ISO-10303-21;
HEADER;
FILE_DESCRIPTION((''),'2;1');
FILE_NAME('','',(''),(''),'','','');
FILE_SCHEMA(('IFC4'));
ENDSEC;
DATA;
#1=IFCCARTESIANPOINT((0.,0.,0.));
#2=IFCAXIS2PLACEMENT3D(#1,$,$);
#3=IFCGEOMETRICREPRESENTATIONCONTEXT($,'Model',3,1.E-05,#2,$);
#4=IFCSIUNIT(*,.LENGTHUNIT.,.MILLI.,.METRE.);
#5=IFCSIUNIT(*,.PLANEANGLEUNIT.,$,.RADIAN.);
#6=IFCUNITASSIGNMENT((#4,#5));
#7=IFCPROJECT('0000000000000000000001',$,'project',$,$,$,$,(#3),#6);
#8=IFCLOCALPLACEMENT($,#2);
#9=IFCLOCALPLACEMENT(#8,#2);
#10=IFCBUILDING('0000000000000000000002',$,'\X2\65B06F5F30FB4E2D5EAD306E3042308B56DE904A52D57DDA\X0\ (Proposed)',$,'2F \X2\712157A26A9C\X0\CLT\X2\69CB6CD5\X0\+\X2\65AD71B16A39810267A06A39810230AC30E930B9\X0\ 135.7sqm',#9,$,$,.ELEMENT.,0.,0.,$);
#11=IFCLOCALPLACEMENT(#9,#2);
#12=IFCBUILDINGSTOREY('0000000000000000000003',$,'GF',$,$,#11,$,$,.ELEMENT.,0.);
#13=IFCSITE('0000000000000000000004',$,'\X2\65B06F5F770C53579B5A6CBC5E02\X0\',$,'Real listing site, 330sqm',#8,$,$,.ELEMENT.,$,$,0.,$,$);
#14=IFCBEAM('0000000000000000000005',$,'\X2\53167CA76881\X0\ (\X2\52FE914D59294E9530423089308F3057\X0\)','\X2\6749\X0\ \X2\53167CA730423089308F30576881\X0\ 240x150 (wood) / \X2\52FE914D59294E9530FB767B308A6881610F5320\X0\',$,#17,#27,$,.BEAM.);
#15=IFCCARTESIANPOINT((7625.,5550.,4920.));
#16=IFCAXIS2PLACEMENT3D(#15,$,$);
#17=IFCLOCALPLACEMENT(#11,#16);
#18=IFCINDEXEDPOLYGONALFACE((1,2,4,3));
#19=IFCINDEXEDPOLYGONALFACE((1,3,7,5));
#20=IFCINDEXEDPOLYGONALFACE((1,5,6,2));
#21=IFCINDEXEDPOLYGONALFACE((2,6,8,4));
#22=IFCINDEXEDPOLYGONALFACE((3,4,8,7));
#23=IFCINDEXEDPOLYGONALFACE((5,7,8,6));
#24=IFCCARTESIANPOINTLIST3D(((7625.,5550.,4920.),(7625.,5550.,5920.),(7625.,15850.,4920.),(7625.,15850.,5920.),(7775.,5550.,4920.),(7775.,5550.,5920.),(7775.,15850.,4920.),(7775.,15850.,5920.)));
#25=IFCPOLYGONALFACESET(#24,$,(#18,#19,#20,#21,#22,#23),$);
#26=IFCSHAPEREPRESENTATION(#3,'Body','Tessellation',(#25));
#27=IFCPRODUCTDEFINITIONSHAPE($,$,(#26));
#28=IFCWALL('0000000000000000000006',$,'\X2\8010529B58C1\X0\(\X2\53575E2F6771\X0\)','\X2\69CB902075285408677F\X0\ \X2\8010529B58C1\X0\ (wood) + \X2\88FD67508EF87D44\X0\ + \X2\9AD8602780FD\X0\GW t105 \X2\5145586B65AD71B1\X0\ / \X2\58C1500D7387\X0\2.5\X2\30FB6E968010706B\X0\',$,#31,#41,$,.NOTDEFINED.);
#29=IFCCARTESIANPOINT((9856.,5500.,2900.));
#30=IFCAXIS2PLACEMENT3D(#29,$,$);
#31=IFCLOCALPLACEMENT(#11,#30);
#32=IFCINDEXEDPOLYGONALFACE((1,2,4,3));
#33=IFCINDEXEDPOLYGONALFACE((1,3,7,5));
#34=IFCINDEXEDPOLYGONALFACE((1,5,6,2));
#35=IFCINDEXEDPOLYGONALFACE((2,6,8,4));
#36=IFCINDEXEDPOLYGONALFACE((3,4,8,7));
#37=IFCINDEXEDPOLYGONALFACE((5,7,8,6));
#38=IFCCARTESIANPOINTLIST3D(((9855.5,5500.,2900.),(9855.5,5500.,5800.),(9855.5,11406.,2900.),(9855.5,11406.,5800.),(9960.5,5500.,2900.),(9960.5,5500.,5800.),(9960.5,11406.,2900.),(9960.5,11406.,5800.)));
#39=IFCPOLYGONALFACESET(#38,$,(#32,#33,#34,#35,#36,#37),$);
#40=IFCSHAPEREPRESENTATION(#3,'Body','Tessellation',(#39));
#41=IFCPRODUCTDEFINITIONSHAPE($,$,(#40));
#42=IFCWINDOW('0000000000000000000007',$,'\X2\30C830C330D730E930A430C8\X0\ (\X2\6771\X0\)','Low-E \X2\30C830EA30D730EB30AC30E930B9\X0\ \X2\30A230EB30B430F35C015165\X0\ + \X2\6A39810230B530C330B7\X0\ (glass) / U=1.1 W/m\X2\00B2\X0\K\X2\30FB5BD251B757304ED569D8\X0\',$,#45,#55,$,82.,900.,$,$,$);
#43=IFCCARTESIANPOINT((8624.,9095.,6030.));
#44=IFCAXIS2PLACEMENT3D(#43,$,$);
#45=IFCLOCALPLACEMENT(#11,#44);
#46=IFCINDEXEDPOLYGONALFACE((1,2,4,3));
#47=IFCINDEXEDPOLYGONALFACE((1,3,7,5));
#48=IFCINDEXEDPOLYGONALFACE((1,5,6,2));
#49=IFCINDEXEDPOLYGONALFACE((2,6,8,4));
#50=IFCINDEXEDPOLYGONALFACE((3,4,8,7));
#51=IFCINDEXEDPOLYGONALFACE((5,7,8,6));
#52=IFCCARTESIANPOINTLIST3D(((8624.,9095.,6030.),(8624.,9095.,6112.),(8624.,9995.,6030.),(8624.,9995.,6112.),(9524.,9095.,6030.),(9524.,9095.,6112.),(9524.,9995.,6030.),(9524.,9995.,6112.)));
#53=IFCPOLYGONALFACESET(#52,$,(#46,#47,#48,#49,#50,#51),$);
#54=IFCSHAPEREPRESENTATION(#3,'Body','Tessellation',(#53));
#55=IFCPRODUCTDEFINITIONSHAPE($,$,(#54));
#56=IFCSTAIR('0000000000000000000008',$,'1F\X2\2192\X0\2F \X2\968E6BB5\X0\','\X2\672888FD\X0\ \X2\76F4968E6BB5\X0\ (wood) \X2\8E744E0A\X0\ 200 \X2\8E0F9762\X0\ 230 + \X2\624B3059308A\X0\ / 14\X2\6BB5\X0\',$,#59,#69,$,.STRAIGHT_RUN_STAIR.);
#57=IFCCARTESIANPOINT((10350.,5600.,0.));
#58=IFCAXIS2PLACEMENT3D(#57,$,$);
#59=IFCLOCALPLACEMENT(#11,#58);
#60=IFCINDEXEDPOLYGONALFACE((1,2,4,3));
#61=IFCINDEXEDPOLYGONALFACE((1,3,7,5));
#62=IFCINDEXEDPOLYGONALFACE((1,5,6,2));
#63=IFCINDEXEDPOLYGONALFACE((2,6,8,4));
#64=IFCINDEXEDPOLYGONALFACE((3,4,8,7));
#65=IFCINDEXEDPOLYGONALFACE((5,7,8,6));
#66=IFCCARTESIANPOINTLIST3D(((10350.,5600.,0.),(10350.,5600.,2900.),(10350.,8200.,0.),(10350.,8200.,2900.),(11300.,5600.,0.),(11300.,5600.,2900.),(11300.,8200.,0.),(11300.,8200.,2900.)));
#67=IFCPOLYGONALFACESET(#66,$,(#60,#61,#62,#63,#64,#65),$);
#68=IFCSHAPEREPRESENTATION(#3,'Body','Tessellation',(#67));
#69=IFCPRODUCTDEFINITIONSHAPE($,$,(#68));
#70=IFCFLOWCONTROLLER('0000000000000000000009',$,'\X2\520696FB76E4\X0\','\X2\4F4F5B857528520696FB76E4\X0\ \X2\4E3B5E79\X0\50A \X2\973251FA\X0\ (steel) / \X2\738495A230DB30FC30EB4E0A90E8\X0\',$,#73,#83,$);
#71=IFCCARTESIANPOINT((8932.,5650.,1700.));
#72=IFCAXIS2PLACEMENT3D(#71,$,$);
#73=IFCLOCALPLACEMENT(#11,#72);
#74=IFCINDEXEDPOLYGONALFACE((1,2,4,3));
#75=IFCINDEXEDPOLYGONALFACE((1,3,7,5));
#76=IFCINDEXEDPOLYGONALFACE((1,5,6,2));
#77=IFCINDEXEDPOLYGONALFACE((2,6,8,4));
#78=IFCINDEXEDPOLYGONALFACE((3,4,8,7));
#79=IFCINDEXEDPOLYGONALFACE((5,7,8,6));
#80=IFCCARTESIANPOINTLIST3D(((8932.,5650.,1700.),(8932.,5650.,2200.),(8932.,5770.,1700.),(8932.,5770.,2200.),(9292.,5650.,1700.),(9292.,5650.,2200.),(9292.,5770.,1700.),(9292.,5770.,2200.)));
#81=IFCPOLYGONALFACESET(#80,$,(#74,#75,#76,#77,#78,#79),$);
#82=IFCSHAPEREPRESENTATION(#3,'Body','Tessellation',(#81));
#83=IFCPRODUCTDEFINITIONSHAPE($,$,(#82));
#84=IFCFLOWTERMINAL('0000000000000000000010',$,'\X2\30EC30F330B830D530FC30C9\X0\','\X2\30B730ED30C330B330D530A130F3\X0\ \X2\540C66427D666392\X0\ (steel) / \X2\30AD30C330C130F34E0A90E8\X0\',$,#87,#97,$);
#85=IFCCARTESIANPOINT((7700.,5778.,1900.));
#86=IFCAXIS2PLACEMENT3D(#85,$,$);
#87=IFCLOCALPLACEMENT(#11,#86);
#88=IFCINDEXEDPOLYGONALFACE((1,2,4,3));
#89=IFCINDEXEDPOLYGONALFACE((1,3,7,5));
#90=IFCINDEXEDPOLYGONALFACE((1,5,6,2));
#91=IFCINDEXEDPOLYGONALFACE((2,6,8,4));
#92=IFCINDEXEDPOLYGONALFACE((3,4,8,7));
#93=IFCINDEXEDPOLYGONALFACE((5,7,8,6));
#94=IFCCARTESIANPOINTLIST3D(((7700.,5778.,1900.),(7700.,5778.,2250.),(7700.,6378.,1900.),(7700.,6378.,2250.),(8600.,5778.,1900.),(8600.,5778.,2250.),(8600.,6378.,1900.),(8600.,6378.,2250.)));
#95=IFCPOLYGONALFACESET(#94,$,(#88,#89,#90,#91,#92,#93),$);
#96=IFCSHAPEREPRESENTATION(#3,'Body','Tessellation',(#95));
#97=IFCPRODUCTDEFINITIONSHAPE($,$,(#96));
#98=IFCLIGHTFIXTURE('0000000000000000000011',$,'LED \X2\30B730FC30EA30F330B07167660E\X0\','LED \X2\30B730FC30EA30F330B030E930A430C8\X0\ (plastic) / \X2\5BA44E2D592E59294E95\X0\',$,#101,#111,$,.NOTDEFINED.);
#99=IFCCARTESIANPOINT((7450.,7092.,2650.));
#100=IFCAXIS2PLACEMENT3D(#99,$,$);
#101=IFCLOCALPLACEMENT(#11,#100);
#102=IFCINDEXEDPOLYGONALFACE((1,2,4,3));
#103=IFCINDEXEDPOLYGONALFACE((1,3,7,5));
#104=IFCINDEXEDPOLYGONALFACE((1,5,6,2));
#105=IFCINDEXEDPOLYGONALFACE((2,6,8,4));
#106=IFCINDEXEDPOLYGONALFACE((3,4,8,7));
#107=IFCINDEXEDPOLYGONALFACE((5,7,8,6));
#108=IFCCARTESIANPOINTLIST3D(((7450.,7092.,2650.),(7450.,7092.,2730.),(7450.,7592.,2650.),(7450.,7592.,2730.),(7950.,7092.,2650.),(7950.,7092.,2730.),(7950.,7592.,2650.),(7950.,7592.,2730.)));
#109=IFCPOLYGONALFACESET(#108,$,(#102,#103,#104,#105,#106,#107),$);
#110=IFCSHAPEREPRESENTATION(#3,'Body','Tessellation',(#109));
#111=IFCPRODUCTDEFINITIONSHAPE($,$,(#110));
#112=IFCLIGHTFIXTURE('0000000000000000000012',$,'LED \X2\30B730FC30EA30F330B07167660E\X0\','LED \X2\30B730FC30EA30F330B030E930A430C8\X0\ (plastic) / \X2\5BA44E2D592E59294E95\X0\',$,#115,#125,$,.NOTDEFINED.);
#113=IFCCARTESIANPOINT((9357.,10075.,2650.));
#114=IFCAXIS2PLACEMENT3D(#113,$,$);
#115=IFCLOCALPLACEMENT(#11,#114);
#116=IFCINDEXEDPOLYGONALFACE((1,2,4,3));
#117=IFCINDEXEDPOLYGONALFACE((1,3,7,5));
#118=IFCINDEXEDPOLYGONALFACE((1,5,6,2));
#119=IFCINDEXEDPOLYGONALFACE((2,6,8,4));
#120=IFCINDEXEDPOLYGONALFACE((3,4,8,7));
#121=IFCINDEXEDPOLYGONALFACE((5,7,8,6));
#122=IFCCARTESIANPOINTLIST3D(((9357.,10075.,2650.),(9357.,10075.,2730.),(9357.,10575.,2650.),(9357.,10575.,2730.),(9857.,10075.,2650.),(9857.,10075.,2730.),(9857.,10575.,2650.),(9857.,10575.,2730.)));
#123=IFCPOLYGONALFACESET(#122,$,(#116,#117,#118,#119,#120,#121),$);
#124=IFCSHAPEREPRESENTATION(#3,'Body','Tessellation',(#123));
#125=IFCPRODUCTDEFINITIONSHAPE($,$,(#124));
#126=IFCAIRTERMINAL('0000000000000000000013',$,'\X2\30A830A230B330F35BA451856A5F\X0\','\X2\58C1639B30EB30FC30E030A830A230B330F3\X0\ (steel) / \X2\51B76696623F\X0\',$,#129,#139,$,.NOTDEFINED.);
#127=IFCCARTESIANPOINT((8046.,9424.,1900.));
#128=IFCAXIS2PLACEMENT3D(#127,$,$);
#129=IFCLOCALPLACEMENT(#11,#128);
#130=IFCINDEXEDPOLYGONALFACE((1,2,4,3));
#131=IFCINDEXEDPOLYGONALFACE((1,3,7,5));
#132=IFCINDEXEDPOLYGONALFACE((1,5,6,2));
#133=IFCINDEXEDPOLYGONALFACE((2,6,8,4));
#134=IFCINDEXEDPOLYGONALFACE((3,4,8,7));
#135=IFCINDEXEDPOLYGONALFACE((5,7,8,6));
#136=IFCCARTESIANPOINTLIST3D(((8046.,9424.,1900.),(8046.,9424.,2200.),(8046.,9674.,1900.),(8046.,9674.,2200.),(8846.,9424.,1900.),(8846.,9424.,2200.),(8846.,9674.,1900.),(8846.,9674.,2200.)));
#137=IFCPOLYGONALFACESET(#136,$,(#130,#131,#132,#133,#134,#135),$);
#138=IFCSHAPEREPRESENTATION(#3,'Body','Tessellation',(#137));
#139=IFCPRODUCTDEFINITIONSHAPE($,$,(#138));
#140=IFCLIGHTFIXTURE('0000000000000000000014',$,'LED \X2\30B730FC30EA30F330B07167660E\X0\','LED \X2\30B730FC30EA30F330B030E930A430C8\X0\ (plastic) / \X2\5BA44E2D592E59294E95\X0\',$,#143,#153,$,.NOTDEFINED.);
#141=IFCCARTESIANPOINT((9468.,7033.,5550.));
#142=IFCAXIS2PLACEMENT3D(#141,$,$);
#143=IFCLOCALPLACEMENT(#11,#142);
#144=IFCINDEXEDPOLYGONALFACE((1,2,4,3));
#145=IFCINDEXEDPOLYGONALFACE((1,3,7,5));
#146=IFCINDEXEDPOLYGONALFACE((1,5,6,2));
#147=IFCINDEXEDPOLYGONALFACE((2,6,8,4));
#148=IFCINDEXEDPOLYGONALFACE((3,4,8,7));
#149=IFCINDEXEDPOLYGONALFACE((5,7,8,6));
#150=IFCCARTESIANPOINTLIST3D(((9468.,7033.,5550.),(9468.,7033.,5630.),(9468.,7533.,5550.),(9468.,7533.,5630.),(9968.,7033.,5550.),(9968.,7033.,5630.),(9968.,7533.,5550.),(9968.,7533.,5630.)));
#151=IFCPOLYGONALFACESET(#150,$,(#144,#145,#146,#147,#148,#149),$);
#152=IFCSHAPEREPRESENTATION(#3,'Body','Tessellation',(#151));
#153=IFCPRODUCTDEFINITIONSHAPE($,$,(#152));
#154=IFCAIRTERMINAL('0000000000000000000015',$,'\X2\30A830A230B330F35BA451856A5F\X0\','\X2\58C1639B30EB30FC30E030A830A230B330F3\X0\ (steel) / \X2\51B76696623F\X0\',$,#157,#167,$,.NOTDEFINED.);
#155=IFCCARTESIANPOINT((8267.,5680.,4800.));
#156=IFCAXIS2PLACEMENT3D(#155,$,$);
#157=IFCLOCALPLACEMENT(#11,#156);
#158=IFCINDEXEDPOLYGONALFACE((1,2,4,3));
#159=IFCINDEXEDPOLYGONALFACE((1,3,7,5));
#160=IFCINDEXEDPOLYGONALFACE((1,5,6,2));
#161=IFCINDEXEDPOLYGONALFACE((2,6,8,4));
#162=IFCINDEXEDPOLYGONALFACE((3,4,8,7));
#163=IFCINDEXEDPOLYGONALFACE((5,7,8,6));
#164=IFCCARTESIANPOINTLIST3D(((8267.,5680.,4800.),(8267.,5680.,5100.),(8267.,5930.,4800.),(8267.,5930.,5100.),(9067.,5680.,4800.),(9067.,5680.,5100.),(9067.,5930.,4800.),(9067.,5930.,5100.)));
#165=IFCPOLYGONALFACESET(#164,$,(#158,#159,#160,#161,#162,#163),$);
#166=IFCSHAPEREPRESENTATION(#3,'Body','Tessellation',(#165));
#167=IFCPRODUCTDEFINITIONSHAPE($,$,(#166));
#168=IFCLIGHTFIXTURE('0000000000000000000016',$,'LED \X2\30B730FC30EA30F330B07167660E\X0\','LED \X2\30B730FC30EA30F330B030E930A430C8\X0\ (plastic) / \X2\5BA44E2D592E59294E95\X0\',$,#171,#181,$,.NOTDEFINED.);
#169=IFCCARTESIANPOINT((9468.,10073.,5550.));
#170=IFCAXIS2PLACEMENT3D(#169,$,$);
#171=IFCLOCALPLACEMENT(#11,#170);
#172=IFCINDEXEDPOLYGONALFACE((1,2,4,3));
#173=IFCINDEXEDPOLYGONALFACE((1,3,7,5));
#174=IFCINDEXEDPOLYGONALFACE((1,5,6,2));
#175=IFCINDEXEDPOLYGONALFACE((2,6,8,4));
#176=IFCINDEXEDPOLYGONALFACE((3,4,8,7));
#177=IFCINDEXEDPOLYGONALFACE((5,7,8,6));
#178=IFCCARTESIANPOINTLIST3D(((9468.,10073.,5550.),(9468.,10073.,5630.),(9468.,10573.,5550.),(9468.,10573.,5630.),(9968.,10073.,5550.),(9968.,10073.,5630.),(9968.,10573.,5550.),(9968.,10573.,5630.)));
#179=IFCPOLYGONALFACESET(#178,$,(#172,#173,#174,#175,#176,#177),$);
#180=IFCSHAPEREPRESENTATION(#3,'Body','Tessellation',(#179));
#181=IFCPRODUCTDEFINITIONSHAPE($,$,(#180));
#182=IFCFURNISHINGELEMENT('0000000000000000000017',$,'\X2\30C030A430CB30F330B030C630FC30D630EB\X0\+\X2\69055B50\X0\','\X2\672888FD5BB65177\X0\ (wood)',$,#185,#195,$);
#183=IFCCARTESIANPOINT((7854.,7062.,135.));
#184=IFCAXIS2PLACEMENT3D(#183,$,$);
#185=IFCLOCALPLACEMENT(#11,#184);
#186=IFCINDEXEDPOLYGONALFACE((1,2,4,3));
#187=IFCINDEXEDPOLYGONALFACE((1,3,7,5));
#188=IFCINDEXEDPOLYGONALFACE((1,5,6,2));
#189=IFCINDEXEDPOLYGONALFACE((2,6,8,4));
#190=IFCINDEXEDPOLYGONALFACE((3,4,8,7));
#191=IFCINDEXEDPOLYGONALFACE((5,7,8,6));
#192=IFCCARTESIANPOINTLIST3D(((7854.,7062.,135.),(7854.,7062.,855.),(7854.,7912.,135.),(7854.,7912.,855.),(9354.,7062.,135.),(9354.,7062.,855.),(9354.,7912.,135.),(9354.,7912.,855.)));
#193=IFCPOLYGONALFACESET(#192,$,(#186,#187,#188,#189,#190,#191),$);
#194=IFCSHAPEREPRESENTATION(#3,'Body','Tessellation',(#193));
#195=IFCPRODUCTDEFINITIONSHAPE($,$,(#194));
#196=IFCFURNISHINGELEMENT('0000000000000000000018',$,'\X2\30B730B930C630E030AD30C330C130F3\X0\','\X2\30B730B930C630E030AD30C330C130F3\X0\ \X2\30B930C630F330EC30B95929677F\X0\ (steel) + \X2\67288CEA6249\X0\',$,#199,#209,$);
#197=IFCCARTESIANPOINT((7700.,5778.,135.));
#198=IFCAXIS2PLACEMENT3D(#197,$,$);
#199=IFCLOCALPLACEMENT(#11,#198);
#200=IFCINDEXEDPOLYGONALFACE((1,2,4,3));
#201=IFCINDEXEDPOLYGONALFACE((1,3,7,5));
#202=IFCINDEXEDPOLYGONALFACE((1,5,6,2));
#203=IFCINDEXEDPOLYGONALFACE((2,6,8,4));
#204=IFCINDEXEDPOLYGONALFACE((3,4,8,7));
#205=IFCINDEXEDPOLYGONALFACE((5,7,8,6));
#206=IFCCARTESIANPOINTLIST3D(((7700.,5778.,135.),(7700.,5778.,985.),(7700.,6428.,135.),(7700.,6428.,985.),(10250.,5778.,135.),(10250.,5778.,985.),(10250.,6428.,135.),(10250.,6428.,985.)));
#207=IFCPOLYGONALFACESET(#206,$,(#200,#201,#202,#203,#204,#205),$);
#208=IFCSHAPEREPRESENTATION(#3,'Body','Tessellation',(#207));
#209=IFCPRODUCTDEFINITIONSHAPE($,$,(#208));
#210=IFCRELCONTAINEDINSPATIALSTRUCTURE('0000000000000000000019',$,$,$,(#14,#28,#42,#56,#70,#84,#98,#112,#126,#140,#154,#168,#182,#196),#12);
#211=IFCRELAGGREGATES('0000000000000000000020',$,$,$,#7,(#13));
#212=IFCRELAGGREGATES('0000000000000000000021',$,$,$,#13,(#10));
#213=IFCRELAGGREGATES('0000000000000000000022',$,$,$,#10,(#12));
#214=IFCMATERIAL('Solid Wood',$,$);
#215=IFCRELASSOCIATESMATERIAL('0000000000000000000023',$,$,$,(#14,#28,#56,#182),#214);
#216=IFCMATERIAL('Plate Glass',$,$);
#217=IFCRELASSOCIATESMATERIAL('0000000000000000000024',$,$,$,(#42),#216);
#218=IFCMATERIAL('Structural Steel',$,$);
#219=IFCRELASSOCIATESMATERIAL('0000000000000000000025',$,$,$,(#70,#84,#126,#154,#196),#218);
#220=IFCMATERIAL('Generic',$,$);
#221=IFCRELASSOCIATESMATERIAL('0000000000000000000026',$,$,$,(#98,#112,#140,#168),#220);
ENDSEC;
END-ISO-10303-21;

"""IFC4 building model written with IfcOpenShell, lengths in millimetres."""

from ifc_helpers import new_model, si_unit, frame, frame_2d, origin, place, context, project, spatial, rectangle, extrude, material, element, save


model = new_model("IFC4")

# Units and contexts
model_context = context("Model", 3, precision=1e-05, world=origin())
ifc_project = project(units=[si_unit("LENGTHUNIT", "METRE", prefix="MILLI"), si_unit("PLANEANGLEUNIT", "RADIAN")], contexts=[model_context])

# Site, building, storey
site_placement = place(None, origin())
site = spatial("IfcSite", under=ifc_project, at=site_placement, Name="新潟県南魚沼市", ObjectType="Real listing site, 330sqm", CompositionType="ELEMENT", RefElevation=0.0)
building_placement = place(site_placement, origin())
building = spatial("IfcBuilding", under=site, at=building_placement, Name="新潟・中庭のある回遊動線 (Proposed)", ObjectType="2F 無垢檜CLT構法+断熱樹脂枠樹脂ガラス 135.7sqm", CompositionType="ELEMENT", ElevationOfRefHeight=0.0, ElevationOfTerrain=0.0)
storey_placement = place(building_placement, origin())
storey = spatial("IfcBuildingStorey", under=building, at=storey_placement, Name="GF", CompositionType="ELEMENT", Elevation=0.0)

# Shared definitions
ifc_material_1 = material(Name="Solid Wood")

# Beam
beam_placement = place(storey_placement, frame((7625.0, 5550.0, 4920.0)))
element("IfcBeam", 1, at=beam_placement, inside=storey, material=ifc_material_1, Name="化粧梁 (勾配天井あらわし)", Description="杉 化粧あらわし梁 240x150 (wood) / 勾配天井・登り梁意匠", PredefinedType="BEAM", context=model_context, shape_type="SweptSolid", body=[
    extrude(rectangle(XDim=150.0, YDim=10300.0, at=frame_2d((75.0, 5150.0))), frame((7625.0, 5550.0, 4920.0)), (0.0, 0.0, 1.0), 1000.0),
])

# Wall
wall_1_placement = place(storey_placement, frame((9856.0, 5500.0, 2900.0)))
element("IfcWall", 2, at=wall_1_placement, inside=storey, material=ifc_material_1, Name="耐力壁(南帯東)", Description="構造用合板 耐力壁 (wood) + 製材軸組 + 高性能GW t105 充填断熱 / 壁倍率2.5・準耐火", PredefinedType="NOTDEFINED", context=model_context, shape_type="SweptSolid", body=[
    extrude(rectangle(XDim=105.0, YDim=5906.0, at=frame_2d((52.0, 2953.0))), frame((9856.0, 5500.0, 2900.0)), (0.0, 0.0, 1.0), 2900.0),
])

# Window
ifc_material_2 = material(Name="Plate Glass")
window_placement = place(storey_placement, frame((8624.0, 9095.0, 6030.0)))
element("IfcWindow", 3, at=window_placement, inside=storey, material=ifc_material_2, Name="トップライト (東)", Description="Low-E トリプルガラス アルゴン封入 + 樹脂サッシ (glass) / U=1.1 W/m²K・寒冷地仕様", OverallHeight=82.0, OverallWidth=900.0, context=model_context, shape_type="SweptSolid", body=[
    extrude(rectangle(XDim=900.0, YDim=900.0, at=frame_2d((450.0, 450.0))), frame((8624.0, 9095.0, 6030.0)), (0.0, 0.0, 1.0), 82.0),
])

# Stair
stair_placement = place(storey_placement, frame((10350.0, 5600.0, 0.0)))
element("IfcStair", 4, at=stair_placement, inside=storey, material=ifc_material_1, Name="1F→2F 階段", Description="木製 直階段 (wood) 蹴上 200 踏面 230 + 手すり / 14段", PredefinedType="STRAIGHT_RUN_STAIR", context=model_context, shape_type="SweptSolid", body=[
    extrude(rectangle(XDim=950.0, YDim=2600.0, at=frame_2d((475.0, 1300.0))), frame((10350.0, 5600.0, 0.0)), (0.0, 0.0, 1.0), 2900.0),
])

# Flow controller
ifc_material_3 = material(Name="Structural Steel")
flow_controller_placement = place(storey_placement, frame((8932.0, 5650.0, 1700.0)))
element("IfcFlowController", 5, at=flow_controller_placement, inside=storey, material=ifc_material_3, Name="分電盤", Description="住宅用分電盤 主幹50A 露出 (steel) / 玄関ホール上部", context=model_context, shape_type="SweptSolid", body=[
    extrude(rectangle(XDim=360.0, YDim=120.0, at=frame_2d((180.0, 60.0))), frame((8932.0, 5650.0, 1700.0)), (0.0, 0.0, 1.0), 500.0),
])

# Flow terminal
flow_terminal_placement = place(storey_placement, frame((7700.0, 5778.0, 1900.0)))
element("IfcFlowTerminal", 6, at=flow_terminal_placement, inside=storey, material=ifc_material_3, Name="レンジフード", Description="シロッコファン 同時給排 (steel) / キッチン上部", context=model_context, shape_type="SweptSolid", body=[
    extrude(rectangle(XDim=900.0, YDim=600.0, at=frame_2d((450.0, 300.0))), frame((7700.0, 5778.0, 1900.0)), (0.0, 0.0, 1.0), 350.0),
])

# Light fixtures
ifc_material_4 = material(Name="Generic")
light_fixture_1_placement = place(storey_placement, frame((7450.0, 7092.0, 2650.0)))
element("IfcLightFixture", 7, at=light_fixture_1_placement, inside=storey, material=ifc_material_4, Name="LED シーリング照明", Description="LED シーリングライト (plastic) / 室中央天井", PredefinedType="NOTDEFINED", context=model_context, shape_type="SweptSolid", body=[
    extrude(rectangle(XDim=500.0, YDim=500.0, at=frame_2d((250.0, 250.0))), frame((7450.0, 7092.0, 2650.0)), (0.0, 0.0, 1.0), 80.0),
])
light_fixture_2_placement = place(storey_placement, frame((9357.0, 10075.0, 2650.0)))
element("IfcLightFixture", 8, at=light_fixture_2_placement, inside=storey, material=ifc_material_4, Name="LED シーリング照明", Description="LED シーリングライト (plastic) / 室中央天井", PredefinedType="NOTDEFINED", context=model_context, shape_type="SweptSolid", body=[
    extrude(rectangle(XDim=500.0, YDim=500.0, at=frame_2d((250.0, 250.0))), frame((9357.0, 10075.0, 2650.0)), (0.0, 0.0, 1.0), 80.0),
])

# Air terminal
air_terminal_1_placement = place(storey_placement, frame((8046.0, 9424.0, 1900.0)))
element("IfcAirTerminal", 9, at=air_terminal_1_placement, inside=storey, material=ifc_material_3, Name="エアコン室内機", Description="壁掛ルームエアコン (steel) / 冷暖房", PredefinedType="NOTDEFINED", context=model_context, shape_type="SweptSolid", body=[
    extrude(rectangle(XDim=800.0, YDim=250.0, at=frame_2d((400.0, 125.0))), frame((8046.0, 9424.0, 1900.0)), (0.0, 0.0, 1.0), 300.0),
])

# Light fixture
light_fixture_3_placement = place(storey_placement, frame((9468.0, 7033.0, 5550.0)))
element("IfcLightFixture", 10, at=light_fixture_3_placement, inside=storey, material=ifc_material_4, Name="LED シーリング照明", Description="LED シーリングライト (plastic) / 室中央天井", PredefinedType="NOTDEFINED", context=model_context, shape_type="SweptSolid", body=[
    extrude(rectangle(XDim=500.0, YDim=500.0, at=frame_2d((250.0, 250.0))), frame((9468.0, 7033.0, 5550.0)), (0.0, 0.0, 1.0), 80.0),
])

# Air terminal
air_terminal_2_placement = place(storey_placement, frame((8267.0, 5680.0, 4800.0)))
element("IfcAirTerminal", 11, at=air_terminal_2_placement, inside=storey, material=ifc_material_3, Name="エアコン室内機", Description="壁掛ルームエアコン (steel) / 冷暖房", PredefinedType="NOTDEFINED", context=model_context, shape_type="SweptSolid", body=[
    extrude(rectangle(XDim=800.0, YDim=250.0, at=frame_2d((400.0, 125.0))), frame((8267.0, 5680.0, 4800.0)), (0.0, 0.0, 1.0), 300.0),
])

# Light fixture
light_fixture_4_placement = place(storey_placement, frame((9468.0, 10073.0, 5550.0)))
element("IfcLightFixture", 12, at=light_fixture_4_placement, inside=storey, material=ifc_material_4, Name="LED シーリング照明", Description="LED シーリングライト (plastic) / 室中央天井", PredefinedType="NOTDEFINED", context=model_context, shape_type="SweptSolid", body=[
    extrude(rectangle(XDim=500.0, YDim=500.0, at=frame_2d((250.0, 250.0))), frame((9468.0, 10073.0, 5550.0)), (0.0, 0.0, 1.0), 80.0),
])

# Furnishing elements
furnishing_1_placement = place(storey_placement, frame((7854.0, 7062.0, 135.0)))
element("IfcFurnishingElement", 13, at=furnishing_1_placement, inside=storey, material=ifc_material_1, Name="ダイニングテーブル+椅子", Description="木製家具 (wood)", context=model_context, shape_type="SweptSolid", body=[
    extrude(rectangle(XDim=1500.0, YDim=850.0, at=frame_2d((750.0, 425.0))), frame((7854.0, 7062.0, 135.0)), (0.0, 0.0, 1.0), 720.0),
])
furnishing_2_placement = place(storey_placement, frame((7700.0, 5778.0, 135.0)))
element("IfcFurnishingElement", 14, at=furnishing_2_placement, inside=storey, material=ifc_material_3, Name="システムキッチン", Description="システムキッチン ステンレス天板 (steel) + 木質扉", context=model_context, shape_type="SweptSolid", body=[
    extrude(rectangle(XDim=2550.0, YDim=650.0, at=frame_2d((1275.0, 325.0))), frame((7700.0, 5778.0, 135.0)), (0.0, 0.0, 1.0), 850.0),
])

save(model, "model.ifc")
